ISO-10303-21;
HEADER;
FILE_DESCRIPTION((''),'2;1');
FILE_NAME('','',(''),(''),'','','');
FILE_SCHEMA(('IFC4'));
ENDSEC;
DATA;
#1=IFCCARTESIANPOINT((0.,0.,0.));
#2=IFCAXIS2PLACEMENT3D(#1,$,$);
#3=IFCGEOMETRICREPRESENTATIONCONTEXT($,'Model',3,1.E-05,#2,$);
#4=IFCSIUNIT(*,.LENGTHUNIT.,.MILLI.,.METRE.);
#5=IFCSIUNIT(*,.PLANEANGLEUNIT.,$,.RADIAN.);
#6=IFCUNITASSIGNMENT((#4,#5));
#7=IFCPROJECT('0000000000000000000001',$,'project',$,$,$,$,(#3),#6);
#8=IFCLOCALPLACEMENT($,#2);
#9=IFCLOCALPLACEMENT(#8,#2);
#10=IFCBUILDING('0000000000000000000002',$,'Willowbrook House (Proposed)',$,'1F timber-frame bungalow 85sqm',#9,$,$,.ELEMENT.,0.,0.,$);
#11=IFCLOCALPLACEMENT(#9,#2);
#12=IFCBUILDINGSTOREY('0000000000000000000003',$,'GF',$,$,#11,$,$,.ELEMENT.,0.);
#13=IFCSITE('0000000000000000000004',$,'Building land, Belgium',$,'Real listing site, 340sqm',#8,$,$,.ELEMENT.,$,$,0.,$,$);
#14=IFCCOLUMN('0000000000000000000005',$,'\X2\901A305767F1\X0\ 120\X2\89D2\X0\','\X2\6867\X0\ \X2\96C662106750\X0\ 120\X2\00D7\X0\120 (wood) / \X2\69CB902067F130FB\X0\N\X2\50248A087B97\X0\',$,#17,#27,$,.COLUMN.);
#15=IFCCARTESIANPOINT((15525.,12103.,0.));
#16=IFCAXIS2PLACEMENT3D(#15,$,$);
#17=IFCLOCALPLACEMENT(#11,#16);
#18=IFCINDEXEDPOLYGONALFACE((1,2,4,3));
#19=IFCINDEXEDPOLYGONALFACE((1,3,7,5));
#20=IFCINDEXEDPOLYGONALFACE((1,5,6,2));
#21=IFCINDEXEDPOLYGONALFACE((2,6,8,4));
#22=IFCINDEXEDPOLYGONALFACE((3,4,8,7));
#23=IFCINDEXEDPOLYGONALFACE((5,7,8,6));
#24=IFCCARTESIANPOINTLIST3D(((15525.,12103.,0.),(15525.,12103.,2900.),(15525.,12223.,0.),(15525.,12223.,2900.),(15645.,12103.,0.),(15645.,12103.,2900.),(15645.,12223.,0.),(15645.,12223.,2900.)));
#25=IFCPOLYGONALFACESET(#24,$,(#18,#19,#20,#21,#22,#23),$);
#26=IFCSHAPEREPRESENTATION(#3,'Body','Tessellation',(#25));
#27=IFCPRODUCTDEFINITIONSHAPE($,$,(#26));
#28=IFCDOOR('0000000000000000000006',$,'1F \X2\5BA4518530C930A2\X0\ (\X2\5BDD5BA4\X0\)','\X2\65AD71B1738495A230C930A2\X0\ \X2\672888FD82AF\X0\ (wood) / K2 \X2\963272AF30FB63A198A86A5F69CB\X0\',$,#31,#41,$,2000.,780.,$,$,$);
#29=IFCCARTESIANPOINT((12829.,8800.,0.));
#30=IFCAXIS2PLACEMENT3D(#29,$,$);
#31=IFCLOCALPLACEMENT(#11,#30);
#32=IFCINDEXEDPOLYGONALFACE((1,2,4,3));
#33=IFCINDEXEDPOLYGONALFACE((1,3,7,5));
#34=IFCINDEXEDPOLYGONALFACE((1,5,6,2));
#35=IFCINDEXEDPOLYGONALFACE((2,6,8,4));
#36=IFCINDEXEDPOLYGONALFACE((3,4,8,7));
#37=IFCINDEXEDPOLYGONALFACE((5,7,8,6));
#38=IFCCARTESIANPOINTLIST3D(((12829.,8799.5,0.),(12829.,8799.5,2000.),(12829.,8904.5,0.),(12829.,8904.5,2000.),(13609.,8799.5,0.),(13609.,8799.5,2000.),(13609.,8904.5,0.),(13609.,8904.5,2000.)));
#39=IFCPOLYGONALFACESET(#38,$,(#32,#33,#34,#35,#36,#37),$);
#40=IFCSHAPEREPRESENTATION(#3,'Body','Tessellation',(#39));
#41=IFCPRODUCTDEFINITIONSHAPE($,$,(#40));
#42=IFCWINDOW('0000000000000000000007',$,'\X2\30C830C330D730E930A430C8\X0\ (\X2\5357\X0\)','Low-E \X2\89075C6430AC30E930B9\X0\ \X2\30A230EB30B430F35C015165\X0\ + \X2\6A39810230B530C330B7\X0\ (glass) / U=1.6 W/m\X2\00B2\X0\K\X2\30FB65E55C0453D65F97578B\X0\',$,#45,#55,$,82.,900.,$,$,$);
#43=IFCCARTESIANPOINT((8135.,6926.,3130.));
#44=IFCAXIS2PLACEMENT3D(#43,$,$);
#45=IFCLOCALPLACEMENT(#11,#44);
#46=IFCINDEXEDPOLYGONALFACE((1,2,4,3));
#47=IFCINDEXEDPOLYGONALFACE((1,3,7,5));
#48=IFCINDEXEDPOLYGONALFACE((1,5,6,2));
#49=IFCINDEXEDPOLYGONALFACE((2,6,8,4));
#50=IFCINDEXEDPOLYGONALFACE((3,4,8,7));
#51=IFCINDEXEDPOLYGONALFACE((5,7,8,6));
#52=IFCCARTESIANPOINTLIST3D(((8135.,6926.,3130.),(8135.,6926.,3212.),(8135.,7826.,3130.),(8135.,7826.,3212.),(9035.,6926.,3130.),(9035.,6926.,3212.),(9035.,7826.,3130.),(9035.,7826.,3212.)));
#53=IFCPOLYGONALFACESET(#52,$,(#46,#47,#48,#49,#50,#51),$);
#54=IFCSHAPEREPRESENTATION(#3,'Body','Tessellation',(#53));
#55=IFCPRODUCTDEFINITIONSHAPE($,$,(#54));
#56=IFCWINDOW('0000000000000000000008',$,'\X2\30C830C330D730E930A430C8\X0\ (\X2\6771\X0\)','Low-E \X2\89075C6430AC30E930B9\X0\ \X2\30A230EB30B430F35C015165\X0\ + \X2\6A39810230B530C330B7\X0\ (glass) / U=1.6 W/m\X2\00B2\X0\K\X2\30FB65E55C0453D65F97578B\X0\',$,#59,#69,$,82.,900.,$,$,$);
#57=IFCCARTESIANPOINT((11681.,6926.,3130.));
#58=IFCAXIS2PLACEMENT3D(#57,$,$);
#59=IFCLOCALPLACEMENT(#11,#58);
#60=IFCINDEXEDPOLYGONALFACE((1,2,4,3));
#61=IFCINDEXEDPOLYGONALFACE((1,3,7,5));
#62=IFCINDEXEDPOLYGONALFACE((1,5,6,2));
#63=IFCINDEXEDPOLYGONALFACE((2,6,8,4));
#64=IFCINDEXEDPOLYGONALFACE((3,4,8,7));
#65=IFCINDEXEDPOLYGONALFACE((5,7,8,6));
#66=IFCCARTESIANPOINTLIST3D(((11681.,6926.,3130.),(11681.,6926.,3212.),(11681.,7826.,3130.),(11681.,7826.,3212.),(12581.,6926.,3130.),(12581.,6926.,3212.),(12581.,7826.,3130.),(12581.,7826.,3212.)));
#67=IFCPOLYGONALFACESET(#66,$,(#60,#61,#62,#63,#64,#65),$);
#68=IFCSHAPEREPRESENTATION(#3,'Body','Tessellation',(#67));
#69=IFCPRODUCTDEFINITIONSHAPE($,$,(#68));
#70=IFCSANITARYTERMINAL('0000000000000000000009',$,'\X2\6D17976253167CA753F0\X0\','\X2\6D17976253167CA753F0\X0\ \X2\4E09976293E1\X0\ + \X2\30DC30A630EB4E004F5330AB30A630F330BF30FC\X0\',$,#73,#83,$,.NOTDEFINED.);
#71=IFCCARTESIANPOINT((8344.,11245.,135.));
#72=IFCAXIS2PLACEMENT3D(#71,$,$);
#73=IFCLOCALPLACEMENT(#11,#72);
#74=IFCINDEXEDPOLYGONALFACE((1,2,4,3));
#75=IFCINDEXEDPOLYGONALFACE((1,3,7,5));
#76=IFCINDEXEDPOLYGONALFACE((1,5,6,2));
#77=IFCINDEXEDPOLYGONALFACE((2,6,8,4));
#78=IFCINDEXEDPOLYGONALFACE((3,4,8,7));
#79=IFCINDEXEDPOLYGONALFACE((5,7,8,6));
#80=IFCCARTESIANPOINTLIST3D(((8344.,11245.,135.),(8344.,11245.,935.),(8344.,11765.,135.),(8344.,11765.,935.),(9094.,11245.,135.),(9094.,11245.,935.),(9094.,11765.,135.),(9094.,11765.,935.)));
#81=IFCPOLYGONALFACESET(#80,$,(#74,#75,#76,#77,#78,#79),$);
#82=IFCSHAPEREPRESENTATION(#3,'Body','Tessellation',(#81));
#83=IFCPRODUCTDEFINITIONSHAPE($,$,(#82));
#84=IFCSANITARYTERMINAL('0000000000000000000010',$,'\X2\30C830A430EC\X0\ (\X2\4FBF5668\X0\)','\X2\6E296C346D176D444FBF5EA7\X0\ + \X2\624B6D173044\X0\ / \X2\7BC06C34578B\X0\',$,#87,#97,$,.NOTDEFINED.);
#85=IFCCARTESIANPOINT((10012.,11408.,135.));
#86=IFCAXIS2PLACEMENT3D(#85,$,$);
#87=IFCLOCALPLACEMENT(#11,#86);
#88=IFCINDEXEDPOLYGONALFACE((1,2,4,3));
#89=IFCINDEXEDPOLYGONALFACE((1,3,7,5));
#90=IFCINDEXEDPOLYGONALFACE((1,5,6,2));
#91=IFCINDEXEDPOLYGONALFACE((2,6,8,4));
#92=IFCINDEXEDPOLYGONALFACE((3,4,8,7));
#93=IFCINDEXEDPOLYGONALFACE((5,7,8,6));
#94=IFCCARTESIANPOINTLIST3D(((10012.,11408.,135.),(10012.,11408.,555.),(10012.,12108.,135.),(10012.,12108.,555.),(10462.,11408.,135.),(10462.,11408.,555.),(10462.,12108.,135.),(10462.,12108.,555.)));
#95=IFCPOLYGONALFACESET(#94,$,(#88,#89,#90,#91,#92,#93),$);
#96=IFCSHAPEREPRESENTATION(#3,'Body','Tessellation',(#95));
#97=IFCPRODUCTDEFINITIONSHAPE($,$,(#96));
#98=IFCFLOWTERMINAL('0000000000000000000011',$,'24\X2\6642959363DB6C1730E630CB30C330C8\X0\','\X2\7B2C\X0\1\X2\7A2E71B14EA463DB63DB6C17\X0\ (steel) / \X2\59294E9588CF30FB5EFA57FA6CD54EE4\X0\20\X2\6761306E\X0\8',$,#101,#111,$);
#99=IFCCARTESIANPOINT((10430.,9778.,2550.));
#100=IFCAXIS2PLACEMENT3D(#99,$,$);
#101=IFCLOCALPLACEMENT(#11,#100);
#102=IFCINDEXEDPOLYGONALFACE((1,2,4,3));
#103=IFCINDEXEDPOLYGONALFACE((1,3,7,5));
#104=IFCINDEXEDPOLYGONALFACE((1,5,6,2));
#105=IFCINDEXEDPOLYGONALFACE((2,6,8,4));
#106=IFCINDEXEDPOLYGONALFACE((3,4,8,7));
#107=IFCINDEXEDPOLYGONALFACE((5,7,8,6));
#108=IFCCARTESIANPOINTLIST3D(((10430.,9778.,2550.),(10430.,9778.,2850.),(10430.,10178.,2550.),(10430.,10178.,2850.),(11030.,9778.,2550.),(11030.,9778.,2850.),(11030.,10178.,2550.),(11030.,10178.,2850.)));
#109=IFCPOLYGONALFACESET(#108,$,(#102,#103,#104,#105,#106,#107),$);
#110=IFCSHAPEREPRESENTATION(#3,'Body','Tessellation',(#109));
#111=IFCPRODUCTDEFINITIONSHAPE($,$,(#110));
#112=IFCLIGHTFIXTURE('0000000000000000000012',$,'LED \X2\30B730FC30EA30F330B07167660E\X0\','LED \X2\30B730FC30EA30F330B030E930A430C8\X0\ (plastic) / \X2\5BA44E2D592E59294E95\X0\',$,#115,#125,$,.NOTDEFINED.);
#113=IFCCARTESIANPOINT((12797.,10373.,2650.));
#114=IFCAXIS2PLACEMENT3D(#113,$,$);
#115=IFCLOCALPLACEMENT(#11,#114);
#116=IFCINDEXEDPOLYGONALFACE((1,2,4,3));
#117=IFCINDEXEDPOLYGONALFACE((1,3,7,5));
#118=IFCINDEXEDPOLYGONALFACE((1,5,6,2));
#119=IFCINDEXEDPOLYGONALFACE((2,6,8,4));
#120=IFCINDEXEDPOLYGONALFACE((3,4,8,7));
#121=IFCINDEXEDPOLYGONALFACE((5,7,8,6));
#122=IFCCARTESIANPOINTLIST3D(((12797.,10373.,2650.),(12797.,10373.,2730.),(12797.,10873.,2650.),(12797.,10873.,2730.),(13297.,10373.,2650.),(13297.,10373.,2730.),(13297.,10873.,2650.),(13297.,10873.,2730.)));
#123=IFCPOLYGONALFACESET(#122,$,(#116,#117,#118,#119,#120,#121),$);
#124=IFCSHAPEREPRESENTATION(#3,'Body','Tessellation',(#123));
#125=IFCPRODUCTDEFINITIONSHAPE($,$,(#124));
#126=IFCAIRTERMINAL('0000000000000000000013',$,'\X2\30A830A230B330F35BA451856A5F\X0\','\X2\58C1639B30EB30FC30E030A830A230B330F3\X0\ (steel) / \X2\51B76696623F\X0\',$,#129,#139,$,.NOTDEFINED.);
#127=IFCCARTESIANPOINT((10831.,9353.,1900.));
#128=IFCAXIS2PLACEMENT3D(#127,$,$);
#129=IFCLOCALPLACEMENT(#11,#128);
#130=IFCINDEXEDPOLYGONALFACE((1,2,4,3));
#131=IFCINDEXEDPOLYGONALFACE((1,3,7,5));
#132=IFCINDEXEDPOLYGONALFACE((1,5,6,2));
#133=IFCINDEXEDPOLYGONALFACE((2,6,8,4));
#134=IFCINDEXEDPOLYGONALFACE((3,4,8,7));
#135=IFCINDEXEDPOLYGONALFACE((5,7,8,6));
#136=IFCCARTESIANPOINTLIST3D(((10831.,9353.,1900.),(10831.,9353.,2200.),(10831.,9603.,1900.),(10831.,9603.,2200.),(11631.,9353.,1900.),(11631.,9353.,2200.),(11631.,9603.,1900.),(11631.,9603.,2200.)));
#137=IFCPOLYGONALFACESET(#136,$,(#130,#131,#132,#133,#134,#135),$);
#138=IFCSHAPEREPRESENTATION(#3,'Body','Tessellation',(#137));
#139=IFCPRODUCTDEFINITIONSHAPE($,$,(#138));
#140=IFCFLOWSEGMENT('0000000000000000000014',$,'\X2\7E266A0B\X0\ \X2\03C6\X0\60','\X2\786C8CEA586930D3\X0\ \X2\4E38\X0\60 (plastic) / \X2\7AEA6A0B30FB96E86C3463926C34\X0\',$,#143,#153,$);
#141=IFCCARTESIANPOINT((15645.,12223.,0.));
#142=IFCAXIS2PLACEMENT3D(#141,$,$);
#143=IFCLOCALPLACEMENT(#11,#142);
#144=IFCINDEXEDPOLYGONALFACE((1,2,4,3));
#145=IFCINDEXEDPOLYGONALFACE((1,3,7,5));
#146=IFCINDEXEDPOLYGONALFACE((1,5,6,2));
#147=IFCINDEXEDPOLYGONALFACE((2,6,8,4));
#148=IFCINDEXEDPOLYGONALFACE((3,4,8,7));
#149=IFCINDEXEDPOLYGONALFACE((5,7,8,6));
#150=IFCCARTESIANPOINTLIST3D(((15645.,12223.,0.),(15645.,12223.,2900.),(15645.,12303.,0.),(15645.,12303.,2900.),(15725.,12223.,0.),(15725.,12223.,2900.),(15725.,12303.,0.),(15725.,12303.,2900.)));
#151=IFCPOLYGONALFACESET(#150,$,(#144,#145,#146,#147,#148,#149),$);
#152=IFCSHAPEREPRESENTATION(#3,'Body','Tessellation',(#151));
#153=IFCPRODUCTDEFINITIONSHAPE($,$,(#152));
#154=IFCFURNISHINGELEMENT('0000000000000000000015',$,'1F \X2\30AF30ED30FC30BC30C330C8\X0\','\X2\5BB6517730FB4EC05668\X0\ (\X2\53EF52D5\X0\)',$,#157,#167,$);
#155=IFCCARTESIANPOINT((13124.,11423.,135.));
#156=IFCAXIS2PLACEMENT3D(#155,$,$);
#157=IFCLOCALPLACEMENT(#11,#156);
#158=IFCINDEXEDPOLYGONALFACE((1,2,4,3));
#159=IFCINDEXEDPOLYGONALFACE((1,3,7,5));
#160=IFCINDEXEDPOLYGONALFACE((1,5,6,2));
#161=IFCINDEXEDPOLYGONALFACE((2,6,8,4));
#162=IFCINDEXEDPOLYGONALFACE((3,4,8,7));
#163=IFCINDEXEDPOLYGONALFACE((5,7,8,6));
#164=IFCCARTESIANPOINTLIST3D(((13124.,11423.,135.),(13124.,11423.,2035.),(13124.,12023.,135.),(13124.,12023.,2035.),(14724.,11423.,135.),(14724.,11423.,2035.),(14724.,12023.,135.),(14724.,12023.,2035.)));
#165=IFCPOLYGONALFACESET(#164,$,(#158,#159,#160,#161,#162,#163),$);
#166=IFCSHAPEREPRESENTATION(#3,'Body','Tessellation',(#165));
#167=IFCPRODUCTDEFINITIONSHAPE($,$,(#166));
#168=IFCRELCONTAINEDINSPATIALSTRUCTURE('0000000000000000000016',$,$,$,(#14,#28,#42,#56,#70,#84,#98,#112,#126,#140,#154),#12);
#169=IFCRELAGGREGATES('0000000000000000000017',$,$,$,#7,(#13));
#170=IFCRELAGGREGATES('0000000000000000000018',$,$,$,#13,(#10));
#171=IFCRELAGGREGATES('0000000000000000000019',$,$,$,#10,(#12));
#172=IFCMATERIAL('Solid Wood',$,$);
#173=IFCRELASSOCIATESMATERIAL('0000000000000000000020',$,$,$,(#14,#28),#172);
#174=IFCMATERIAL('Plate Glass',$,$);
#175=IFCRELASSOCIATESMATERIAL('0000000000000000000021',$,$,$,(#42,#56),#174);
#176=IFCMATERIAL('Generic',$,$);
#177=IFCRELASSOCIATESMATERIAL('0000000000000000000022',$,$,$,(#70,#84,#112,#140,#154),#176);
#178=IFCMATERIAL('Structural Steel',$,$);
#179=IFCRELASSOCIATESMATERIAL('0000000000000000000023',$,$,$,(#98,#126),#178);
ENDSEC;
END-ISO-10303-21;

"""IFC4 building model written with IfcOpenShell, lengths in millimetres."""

from ifc_helpers import new_model, si_unit, frame, frame_2d, origin, place, context, project, spatial, rectangle, extrude, material, element, save


model = new_model("IFC4")

# Units and contexts
model_context = context("Model", 3, precision=1e-05, world=origin())
ifc_project = project(units=[si_unit("LENGTHUNIT", "METRE", prefix="MILLI"), si_unit("PLANEANGLEUNIT", "RADIAN")], contexts=[model_context])

# Site, building, storey
site_placement = place(None, origin())
site = spatial("IfcSite", under=ifc_project, at=site_placement, Name="Building land, Belgium", ObjectType="Real listing site, 340sqm", CompositionType="ELEMENT", RefElevation=0.0)
building_placement = place(site_placement, origin())
building = spatial("IfcBuilding", under=site, at=building_placement, Name="Willowbrook House (Proposed)", ObjectType="1F timber-frame bungalow 85sqm", CompositionType="ELEMENT", ElevationOfRefHeight=0.0, ElevationOfTerrain=0.0)
storey_placement = place(building_placement, origin())
storey = spatial("IfcBuildingStorey", under=building, at=storey_placement, Name="GF", CompositionType="ELEMENT", Elevation=0.0)

# Column
ifc_material_1 = material(Name="Solid Wood")
column_1_placement = place(storey_placement, frame((15525.0, 12103.0, 0.0)))
element("IfcColumn", 1, at=column_1_placement, inside=storey, material=ifc_material_1, Name="通し柱 120角", Description="桧 集成材 120×120 (wood) / 構造柱・N値計算", PredefinedType="COLUMN", context=model_context, shape_type="SweptSolid", body=[
    extrude(rectangle(XDim=120.0, YDim=120.0, at=frame_2d((60.0, 60.0))), frame((15525.0, 12103.0, 0.0)), (0.0, 0.0, 1.0), 2900.0),
])

# Door
door_placement = place(storey_placement, frame((12829.0, 8800.0, 0.0)))
element("IfcDoor", 2, at=door_placement, inside=storey, material=ifc_material_1, Name="1F 室内ドア (寝室)", Description="断熱玄関ドア 木製芯 (wood) / K2 防犯・採風機構", OverallHeight=2000.0, OverallWidth=780.0, context=model_context, shape_type="SweptSolid", body=[
    extrude(rectangle(XDim=780.0, YDim=105.0, at=frame_2d((390.0, 52.0))), frame((12829.0, 8800.0, 0.0)), (0.0, 0.0, 1.0), 2000.0),
])

# Windows
ifc_material_2 = material(Name="Plate Glass")
window_1_placement = place(storey_placement, frame((8135.0, 6926.0, 3130.0)))
element("IfcWindow", 3, at=window_1_placement, inside=storey, material=ifc_material_2, Name="トップライト (南)", Description="Low-E 複層ガラス アルゴン封入 + 樹脂サッシ (glass) / U=1.6 W/m²K・日射取得型", OverallHeight=82.0, OverallWidth=900.0, context=model_context, shape_type="SweptSolid", body=[
    extrude(rectangle(XDim=900.0, YDim=900.0, at=frame_2d((450.0, 450.0))), frame((8135.0, 6926.0, 3130.0)), (0.0, 0.0, 1.0), 82.0),
])
window_2_placement = place(storey_placement, frame((11681.0, 6926.0, 3130.0)))
element("IfcWindow", 4, at=window_2_placement, inside=storey, material=ifc_material_2, Name="トップライト (東)", Description="Low-E 複層ガラス アルゴン封入 + 樹脂サッシ (glass) / U=1.6 W/m²K・日射取得型", OverallHeight=82.0, OverallWidth=900.0, context=model_context, shape_type="SweptSolid", body=[
    extrude(rectangle(XDim=900.0, YDim=900.0, at=frame_2d((450.0, 450.0))), frame((11681.0, 6926.0, 3130.0)), (0.0, 0.0, 1.0), 82.0),
])

# Sanitary terminals
ifc_material_3 = material(Name="Generic")
sanitary_terminal_1_placement = place(storey_placement, frame((8344.0, 11245.0, 135.0)))
element("IfcSanitaryTerminal", 5, at=sanitary_terminal_1_placement, inside=storey, material=ifc_material_3, Name="洗面化粧台", Description="洗面化粧台 三面鏡 + ボウル一体カウンター", PredefinedType="NOTDEFINED", context=model_context, shape_type="SweptSolid", body=[
    extrude(rectangle(XDim=750.0, YDim=520.0, at=frame_2d((375.0, 260.0))), frame((8344.0, 11245.0, 135.0)), (0.0, 0.0, 1.0), 800.0),
])
sanitary_terminal_2_placement = place(storey_placement, frame((10012.0, 11408.0, 135.0)))
element("IfcSanitaryTerminal", 6, at=sanitary_terminal_2_placement, inside=storey, material=ifc_material_3, Name="トイレ (便器)", Description="温水洗浄便座 + 手洗い / 節水型", PredefinedType="NOTDEFINED", context=model_context, shape_type="SweptSolid", body=[
    extrude(rectangle(XDim=450.0, YDim=700.0, at=frame_2d((225.0, 350.0))), frame((10012.0, 11408.0, 135.0)), (0.0, 0.0, 1.0), 420.0),
])

# Flow terminal
ifc_material_4 = material(Name="Structural Steel")
flow_terminal_placement = place(storey_placement, frame((10430.0, 9778.0, 2550.0)))
element("IfcFlowTerminal", 7, at=flow_terminal_placement, inside=storey, material=ifc_material_4, Name="24時間換気ユニット", Description="第1種熱交換換気 (steel) / 天井裏・建基法令20条の8", context=model_context, shape_type="SweptSolid", body=[
    extrude(rectangle(XDim=600.0, YDim=400.0, at=frame_2d((300.0, 200.0))), frame((10430.0, 9778.0, 2550.0)), (0.0, 0.0, 1.0), 300.0),
])

# Light fixture
light_fixture_placement = place(storey_placement, frame((12797.0, 10373.0, 2650.0)))
element("IfcLightFixture", 8, at=light_fixture_placement, inside=storey, material=ifc_material_3, Name="LED シーリング照明", Description="LED シーリングライト (plastic) / 室中央天井", PredefinedType="NOTDEFINED", context=model_context, shape_type="SweptSolid", body=[
    extrude(rectangle(XDim=500.0, YDim=500.0, at=frame_2d((250.0, 250.0))), frame((12797.0, 10373.0, 2650.0)), (0.0, 0.0, 1.0), 80.0),
])

# Air terminal
air_terminal_placement = place(storey_placement, frame((10831.0, 9353.0, 1900.0)))
element("IfcAirTerminal", 9, at=air_terminal_placement, inside=storey, material=ifc_material_4, Name="エアコン室内機", Description="壁掛ルームエアコン (steel) / 冷暖房", PredefinedType="NOTDEFINED", context=model_context, shape_type="SweptSolid", body=[
    extrude(rectangle(XDim=800.0, YDim=250.0, at=frame_2d((400.0, 125.0))), frame((10831.0, 9353.0, 1900.0)), (0.0, 0.0, 1.0), 300.0),
])

# Flow segment
flow_segment_placement = place(storey_placement, frame((15645.0, 12223.0, 0.0)))
element("IfcFlowSegment", 10, at=flow_segment_placement, inside=storey, material=ifc_material_3, Name="縦樋 φ60", Description="硬質塩ビ 丸60 (plastic) / 竪樋・雨水排水", context=model_context, shape_type="SweptSolid", body=[
    extrude(rectangle(XDim=80.0, YDim=80.0, at=frame_2d((40.0, 40.0))), frame((15645.0, 12223.0, 0.0)), (0.0, 0.0, 1.0), 2900.0),
])

# Furnishing element
furnishing_placement = place(storey_placement, frame((13124.0, 11423.0, 135.0)))
element("IfcFurnishingElement", 11, at=furnishing_placement, inside=storey, material=ifc_material_3, Name="1F クローゼット", Description="家具・什器 (可動)", context=model_context, shape_type="SweptSolid", body=[
    extrude(rectangle(XDim=1600.0, YDim=600.0, at=frame_2d((800.0, 300.0))), frame((13124.0, 11423.0, 135.0)), (0.0, 0.0, 1.0), 1900.0),
])

save(model, "model.ifc")
